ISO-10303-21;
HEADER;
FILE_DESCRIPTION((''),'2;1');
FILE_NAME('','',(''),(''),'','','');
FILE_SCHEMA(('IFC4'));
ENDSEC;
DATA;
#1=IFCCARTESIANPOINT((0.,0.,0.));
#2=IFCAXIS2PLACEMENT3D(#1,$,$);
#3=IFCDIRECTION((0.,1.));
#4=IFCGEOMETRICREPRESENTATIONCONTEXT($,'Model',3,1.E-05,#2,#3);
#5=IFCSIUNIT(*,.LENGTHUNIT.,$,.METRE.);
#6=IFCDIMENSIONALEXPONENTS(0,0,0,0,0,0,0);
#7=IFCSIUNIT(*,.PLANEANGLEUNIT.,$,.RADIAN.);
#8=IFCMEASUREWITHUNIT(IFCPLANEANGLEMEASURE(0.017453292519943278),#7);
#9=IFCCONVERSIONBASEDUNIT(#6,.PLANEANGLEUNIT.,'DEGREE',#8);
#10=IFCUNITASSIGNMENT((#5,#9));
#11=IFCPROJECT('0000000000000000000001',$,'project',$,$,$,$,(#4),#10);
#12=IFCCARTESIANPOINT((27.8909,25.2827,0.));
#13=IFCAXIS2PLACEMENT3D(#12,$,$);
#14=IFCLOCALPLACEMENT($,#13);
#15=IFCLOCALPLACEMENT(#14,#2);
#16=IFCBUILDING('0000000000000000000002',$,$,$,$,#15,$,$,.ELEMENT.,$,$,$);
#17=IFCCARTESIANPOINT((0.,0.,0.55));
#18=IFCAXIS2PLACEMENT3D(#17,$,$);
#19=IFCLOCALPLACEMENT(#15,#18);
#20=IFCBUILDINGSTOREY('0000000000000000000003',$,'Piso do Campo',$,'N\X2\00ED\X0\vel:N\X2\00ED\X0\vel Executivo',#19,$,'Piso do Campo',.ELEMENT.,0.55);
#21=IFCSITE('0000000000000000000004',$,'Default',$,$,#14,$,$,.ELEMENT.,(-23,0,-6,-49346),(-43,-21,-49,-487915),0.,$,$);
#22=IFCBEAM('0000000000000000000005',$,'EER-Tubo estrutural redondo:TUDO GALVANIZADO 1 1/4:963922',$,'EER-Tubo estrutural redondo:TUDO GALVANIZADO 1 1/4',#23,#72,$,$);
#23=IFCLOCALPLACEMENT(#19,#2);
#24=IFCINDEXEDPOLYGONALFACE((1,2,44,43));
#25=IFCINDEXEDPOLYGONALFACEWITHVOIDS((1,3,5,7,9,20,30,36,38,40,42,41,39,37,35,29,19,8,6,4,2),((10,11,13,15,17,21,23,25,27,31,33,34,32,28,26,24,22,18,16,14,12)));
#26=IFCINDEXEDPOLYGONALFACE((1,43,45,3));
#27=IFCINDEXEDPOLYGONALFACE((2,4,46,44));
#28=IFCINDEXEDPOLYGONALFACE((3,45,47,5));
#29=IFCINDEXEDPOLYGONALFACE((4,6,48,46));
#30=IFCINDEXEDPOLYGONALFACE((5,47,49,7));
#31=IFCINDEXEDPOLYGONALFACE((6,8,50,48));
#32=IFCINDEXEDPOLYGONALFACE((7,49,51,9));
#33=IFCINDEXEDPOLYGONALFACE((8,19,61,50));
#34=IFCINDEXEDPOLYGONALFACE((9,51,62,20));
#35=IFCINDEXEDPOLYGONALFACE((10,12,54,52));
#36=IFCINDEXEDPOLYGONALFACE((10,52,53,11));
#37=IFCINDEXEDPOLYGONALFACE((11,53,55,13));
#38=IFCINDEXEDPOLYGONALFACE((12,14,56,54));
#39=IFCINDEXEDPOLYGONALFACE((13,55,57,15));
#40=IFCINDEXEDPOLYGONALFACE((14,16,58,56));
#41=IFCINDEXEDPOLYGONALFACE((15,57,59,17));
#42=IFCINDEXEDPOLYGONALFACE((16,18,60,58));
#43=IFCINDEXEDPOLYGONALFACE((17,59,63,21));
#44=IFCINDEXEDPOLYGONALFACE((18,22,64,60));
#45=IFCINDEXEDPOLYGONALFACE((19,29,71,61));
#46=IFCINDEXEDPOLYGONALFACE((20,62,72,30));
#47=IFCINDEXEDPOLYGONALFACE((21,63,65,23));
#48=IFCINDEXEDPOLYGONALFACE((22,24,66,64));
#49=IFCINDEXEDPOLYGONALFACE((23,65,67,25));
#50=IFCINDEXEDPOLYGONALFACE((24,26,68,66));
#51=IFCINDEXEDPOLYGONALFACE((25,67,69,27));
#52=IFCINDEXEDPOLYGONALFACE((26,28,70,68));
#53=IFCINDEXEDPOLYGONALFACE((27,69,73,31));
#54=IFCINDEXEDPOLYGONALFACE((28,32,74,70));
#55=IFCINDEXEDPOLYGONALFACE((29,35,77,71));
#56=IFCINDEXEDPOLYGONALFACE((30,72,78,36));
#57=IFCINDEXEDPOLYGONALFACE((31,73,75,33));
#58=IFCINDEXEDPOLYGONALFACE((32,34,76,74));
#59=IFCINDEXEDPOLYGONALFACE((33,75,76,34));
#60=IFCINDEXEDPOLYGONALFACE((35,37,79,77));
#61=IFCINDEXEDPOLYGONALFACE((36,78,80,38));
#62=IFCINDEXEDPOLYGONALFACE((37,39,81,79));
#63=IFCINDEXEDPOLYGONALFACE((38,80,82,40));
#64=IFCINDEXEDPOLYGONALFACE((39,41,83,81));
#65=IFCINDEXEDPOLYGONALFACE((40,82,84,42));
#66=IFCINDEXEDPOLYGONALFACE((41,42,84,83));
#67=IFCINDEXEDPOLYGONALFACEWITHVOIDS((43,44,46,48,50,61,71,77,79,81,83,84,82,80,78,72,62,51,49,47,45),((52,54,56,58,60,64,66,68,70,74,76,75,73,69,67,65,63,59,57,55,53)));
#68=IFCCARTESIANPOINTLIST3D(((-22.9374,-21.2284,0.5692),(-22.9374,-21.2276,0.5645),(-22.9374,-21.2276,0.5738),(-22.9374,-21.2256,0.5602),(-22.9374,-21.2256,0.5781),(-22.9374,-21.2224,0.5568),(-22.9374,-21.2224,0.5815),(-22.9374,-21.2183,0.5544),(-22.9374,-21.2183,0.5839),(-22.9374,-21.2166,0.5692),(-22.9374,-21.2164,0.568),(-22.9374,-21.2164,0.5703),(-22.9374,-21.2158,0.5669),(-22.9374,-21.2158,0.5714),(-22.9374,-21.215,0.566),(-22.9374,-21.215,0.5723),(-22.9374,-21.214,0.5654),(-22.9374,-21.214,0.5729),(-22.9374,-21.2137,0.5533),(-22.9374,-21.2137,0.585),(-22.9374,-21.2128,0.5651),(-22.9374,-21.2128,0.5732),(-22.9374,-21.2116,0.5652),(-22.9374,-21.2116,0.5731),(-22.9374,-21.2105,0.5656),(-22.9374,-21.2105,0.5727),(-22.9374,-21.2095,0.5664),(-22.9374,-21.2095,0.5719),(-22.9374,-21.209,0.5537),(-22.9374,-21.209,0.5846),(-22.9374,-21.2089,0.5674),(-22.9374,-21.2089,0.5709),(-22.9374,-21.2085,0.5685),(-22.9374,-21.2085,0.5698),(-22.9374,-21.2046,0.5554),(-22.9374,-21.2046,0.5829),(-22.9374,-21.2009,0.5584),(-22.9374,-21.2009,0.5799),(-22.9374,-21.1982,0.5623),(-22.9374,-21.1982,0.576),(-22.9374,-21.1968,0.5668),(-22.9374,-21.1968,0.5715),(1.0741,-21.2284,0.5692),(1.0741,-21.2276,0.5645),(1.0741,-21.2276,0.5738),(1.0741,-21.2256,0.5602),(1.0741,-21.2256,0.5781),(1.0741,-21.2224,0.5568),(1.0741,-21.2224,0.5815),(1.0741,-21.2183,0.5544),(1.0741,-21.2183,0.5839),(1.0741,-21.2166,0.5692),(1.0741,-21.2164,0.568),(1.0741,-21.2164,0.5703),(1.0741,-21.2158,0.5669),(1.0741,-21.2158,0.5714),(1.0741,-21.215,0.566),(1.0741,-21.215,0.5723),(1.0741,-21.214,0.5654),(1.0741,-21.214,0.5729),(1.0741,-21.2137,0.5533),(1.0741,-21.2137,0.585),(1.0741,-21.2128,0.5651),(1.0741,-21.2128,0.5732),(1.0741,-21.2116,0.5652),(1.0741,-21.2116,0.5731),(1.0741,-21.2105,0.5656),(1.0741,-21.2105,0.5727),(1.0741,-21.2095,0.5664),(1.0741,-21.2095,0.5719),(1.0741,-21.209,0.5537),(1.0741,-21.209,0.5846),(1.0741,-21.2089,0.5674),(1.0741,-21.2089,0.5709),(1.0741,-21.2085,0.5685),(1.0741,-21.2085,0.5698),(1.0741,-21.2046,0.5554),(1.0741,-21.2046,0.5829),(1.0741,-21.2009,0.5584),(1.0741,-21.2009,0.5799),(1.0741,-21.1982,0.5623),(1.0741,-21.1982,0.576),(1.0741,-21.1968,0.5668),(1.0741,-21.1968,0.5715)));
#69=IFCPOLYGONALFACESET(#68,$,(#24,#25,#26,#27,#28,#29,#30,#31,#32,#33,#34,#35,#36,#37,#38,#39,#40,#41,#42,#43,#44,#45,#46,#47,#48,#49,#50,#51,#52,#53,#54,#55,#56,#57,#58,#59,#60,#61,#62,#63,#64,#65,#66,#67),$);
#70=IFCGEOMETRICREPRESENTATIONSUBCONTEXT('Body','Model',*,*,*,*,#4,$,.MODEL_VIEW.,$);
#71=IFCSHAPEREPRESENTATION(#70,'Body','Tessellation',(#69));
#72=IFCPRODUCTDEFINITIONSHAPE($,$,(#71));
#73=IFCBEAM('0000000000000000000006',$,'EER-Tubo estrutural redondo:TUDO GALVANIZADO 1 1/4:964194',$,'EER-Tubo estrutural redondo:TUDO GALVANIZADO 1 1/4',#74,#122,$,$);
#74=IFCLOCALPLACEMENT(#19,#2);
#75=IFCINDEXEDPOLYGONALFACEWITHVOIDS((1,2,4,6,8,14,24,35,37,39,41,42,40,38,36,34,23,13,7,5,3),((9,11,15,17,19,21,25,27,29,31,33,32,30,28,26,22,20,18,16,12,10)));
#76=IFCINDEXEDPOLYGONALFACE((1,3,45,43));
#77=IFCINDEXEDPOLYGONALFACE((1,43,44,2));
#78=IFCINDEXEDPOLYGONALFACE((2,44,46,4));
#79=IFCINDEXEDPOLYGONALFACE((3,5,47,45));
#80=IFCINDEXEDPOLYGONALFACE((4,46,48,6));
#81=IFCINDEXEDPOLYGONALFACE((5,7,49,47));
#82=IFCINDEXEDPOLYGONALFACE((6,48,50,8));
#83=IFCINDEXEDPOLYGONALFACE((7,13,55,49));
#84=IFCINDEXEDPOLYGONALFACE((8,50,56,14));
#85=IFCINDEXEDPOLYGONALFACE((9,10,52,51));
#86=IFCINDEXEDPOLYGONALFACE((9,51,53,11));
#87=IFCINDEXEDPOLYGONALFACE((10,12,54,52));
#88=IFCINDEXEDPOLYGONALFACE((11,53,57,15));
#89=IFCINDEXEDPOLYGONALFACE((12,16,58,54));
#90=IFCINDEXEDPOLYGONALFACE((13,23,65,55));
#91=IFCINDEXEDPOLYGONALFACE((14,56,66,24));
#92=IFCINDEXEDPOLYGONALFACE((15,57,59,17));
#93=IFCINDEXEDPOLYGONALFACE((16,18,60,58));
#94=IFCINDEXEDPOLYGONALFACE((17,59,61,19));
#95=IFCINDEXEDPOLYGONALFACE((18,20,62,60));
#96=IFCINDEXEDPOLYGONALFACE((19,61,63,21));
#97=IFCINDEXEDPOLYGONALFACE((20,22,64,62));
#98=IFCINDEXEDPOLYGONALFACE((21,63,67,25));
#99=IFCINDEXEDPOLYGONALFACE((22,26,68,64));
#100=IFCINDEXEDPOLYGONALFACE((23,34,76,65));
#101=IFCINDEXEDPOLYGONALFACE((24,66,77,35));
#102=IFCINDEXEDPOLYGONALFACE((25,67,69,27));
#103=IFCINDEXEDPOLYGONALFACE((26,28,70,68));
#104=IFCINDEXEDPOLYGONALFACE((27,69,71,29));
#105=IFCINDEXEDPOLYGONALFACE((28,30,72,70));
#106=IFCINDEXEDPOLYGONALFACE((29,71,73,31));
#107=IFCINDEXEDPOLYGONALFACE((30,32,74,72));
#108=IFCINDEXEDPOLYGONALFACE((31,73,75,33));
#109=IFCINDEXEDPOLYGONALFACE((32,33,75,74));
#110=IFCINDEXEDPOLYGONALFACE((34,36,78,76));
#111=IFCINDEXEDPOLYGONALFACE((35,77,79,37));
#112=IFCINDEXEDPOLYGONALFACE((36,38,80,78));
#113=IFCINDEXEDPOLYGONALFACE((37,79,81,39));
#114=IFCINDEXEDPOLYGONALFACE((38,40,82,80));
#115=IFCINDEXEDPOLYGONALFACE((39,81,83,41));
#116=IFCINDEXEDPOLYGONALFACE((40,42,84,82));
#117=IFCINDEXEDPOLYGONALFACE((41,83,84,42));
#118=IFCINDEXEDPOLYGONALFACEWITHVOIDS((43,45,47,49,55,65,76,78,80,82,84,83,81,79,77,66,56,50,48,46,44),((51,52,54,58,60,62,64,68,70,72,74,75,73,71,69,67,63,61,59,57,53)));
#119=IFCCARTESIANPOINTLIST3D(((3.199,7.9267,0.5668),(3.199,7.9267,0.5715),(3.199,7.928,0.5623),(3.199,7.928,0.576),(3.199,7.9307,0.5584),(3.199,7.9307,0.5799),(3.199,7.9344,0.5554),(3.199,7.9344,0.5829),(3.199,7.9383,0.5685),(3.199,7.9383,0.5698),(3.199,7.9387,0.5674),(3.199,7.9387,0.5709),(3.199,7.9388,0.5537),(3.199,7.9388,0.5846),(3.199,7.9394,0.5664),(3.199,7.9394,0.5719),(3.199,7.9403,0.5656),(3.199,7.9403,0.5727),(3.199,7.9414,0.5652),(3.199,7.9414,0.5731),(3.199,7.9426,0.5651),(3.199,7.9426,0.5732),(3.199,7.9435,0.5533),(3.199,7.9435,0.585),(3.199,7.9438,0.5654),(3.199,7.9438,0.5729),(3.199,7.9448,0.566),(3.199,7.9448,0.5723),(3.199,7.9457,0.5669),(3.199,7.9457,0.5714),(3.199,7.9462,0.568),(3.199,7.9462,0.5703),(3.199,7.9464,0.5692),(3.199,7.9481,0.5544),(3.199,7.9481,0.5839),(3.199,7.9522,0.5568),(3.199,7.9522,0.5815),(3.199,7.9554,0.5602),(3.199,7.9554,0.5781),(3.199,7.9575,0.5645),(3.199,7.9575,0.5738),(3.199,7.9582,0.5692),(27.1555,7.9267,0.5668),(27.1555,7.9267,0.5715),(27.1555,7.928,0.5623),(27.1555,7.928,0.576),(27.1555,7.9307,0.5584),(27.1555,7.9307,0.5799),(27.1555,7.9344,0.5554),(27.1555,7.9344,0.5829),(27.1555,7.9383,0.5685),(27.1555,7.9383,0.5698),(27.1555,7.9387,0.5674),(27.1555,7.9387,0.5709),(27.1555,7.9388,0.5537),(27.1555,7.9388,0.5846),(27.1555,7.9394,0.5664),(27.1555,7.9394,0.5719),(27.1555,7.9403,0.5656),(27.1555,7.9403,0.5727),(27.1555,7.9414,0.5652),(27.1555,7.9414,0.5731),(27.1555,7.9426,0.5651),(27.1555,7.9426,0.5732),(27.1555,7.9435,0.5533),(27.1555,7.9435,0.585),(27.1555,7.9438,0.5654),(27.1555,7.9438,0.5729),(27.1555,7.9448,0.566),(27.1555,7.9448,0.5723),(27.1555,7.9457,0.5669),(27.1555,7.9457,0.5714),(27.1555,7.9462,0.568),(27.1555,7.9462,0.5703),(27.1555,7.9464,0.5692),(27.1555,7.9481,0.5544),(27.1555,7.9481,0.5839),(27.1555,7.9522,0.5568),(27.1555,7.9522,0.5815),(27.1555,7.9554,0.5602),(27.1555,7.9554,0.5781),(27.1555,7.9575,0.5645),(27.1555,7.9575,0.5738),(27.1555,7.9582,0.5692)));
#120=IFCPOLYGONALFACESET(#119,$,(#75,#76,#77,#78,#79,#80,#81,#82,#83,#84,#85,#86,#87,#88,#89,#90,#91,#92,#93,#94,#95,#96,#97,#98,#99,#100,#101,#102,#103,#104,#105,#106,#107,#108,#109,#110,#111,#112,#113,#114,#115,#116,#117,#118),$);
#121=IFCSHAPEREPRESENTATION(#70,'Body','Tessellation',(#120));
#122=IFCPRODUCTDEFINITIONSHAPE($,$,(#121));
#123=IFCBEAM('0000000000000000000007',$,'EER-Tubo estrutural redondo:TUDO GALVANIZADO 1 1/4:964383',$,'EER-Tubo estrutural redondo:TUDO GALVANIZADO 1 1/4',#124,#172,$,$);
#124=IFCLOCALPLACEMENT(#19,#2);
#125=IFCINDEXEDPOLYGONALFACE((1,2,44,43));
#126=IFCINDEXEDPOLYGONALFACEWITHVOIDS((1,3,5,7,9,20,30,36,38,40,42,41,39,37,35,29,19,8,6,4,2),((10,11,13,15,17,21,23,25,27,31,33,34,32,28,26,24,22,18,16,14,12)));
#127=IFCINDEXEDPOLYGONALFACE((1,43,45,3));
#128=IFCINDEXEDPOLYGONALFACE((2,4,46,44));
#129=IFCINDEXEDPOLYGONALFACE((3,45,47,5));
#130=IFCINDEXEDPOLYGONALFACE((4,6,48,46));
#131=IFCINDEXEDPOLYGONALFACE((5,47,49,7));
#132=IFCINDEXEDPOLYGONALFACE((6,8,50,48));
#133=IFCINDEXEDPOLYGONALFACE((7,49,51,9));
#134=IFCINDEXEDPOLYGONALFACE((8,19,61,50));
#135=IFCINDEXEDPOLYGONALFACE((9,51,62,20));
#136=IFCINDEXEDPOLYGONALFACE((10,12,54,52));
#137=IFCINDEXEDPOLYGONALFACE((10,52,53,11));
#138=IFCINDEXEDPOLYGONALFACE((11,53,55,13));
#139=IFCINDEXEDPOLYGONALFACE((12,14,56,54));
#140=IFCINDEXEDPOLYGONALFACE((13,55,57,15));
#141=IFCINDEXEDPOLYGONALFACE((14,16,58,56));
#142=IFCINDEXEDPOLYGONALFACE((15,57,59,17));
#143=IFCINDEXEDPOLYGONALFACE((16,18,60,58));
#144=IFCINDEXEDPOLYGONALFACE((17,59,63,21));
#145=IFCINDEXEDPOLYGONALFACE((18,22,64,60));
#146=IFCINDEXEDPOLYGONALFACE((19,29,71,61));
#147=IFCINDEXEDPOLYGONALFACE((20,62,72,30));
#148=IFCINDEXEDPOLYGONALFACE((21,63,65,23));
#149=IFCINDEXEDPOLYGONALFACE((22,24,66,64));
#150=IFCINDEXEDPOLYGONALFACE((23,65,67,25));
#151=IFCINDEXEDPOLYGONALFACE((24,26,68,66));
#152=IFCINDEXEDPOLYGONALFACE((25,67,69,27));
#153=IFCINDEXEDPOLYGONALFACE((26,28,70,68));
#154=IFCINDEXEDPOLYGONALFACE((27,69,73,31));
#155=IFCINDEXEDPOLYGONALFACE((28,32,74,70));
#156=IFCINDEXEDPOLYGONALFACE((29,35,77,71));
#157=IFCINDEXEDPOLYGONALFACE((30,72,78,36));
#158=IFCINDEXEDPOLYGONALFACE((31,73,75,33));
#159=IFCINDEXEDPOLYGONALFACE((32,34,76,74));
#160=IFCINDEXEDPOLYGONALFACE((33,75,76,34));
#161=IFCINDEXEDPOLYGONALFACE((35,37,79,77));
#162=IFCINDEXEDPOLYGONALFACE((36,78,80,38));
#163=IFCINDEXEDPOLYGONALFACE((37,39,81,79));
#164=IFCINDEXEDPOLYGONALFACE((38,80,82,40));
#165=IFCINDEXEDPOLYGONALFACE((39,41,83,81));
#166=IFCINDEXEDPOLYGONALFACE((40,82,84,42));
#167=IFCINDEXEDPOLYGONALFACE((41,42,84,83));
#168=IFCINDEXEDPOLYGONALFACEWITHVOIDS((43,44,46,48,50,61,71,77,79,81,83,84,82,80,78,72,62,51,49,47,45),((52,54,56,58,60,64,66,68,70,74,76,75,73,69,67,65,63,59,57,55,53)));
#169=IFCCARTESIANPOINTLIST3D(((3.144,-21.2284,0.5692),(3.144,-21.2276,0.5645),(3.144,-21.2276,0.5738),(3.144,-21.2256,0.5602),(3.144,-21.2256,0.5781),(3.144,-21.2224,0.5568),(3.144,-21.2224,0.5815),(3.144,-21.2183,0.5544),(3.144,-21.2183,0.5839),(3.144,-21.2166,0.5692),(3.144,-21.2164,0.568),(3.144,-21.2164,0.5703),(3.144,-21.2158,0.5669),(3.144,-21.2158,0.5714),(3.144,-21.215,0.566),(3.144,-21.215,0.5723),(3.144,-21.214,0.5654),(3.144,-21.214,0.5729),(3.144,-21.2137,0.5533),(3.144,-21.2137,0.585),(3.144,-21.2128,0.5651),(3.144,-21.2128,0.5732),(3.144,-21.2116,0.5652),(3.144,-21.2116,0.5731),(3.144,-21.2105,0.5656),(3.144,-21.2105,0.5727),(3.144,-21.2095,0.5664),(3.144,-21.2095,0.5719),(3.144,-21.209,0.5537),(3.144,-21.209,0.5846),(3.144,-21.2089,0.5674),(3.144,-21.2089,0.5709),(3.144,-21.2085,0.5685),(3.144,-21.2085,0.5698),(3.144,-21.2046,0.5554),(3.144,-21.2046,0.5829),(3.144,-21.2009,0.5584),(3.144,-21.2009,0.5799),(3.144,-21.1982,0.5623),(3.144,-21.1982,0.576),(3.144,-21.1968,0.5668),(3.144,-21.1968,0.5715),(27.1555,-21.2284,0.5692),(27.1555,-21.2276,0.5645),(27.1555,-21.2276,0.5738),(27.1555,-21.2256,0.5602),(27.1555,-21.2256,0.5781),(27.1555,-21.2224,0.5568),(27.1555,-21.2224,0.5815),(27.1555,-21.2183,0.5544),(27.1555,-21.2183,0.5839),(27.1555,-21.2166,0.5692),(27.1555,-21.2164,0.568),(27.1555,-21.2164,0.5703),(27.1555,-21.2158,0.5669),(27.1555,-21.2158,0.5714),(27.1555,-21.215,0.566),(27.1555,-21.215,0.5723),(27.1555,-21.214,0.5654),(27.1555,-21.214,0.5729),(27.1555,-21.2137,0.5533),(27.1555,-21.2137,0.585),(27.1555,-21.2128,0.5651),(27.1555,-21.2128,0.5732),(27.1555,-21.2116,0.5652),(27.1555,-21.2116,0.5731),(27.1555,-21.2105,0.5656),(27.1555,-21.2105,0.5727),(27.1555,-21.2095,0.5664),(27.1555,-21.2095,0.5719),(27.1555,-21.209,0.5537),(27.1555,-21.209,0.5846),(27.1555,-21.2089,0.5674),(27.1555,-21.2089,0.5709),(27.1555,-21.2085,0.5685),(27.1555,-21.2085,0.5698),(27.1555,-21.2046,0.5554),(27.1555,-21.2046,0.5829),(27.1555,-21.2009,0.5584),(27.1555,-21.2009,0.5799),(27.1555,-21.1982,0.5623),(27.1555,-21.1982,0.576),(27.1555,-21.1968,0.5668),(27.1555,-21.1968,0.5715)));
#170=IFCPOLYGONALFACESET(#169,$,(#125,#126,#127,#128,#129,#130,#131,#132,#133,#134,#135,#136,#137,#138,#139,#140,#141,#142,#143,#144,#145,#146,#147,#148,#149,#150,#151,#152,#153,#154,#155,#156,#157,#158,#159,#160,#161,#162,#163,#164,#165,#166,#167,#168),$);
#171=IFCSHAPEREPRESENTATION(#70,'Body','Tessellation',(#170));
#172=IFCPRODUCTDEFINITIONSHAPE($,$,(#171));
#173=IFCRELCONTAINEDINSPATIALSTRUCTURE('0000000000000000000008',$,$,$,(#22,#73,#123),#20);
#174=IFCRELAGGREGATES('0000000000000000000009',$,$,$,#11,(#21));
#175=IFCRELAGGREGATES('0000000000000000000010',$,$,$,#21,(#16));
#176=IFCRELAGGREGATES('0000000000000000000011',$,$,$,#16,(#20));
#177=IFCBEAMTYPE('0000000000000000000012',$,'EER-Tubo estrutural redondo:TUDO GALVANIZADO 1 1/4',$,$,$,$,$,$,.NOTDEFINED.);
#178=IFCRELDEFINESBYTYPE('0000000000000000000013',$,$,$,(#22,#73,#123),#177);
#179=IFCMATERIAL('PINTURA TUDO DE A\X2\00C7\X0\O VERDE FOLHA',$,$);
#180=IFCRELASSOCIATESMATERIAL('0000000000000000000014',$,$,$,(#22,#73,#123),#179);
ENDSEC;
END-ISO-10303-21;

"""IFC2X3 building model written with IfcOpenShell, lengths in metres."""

from ifc_helpers import new_model, entity, si_unit, converted_unit, direction, frame, origin, origin_2d_with_axis, place, context, subcontext, project, spatial, hollow_circle, extrude, material, type_object, element, save


model = new_model("IFC2X3")

# Units and contexts
model_context = context("Model", 3, precision=1e-05, world=origin(), true_north=direction((0.0, 1.0)))
body_context = subcontext(model_context, "Body", "Model", "MODEL_VIEW")
ifc_project = project(units=[si_unit("LENGTHUNIT", "METRE"), converted_unit("PLANEANGLEUNIT", "DEGREE", entity("IfcPlaneAngleMeasure", 0.017453292519943278), si_unit("PLANEANGLEUNIT", "RADIAN"), dimensions=[0, 0, 0, 0, 0, 0, 0])], contexts=[model_context])

# Site, building, storey
site_placement = place(None, frame((27.8909, 25.2827, 0.0)))
site = spatial("IfcSite", under=ifc_project, at=site_placement, Name="Default", CompositionType="ELEMENT", RefLatitude=(-23, 0, -6, -49346), RefLongitude=(-43, -21, -49, -487915), RefElevation=0.0)
building_placement = place(site_placement, origin())
building = spatial("IfcBuilding", under=site, at=building_placement, CompositionType="ELEMENT")
storey_placement = place(building_placement, frame((0.0, 0.0, 0.55)))
storey = spatial("IfcBuildingStorey", under=building, at=storey_placement, Name="Piso do Campo", ObjectType="Nível:Nível Executivo", LongName="Piso do Campo", CompositionType="ELEMENT", Elevation=0.55)

# Beams
ifc_material = material(Name="PINTURA TUDO DE AÇO VERDE FOLHA")
beam_type = type_object("IfcBeamType", Name="EER-Tubo estrutural redondo:TUDO GALVANIZADO 1 1/4", PredefinedType="NOTDEFINED")
beam_1_placement = place(storey_placement, frame((-22.9659, -21.2125, 0.585)))
element("IfcBeam", 1, at=beam_1_placement, inside=storey, type_object=beam_type, material=ifc_material, Name="EER-Tubo estrutural redondo:TUDO GALVANIZADO 1 1/4:963922", ObjectType="EER-Tubo estrutural redondo:TUDO GALVANIZADO 1 1/4", context=body_context, shape_type="SweptSolid", body=[
    extrude(hollow_circle(Radius=0.0159, WallThickness=0.0118, at=origin_2d_with_axis()), frame((0.0286, 0.0, -0.0159), z_axis=(1.0, 0.0, 0.0), x_axis=(0.0, -1.0, 0.0)), (0.0, 0.0, 1.0), 24.0115),
])
beam_2_placement = place(storey_placement, frame((2.2041, 7.9423, 0.585)))
element("IfcBeam", 2, at=beam_2_placement, inside=storey, type_object=beam_type, material=ifc_material, Name="EER-Tubo estrutural redondo:TUDO GALVANIZADO 1 1/4:964194", ObjectType="EER-Tubo estrutural redondo:TUDO GALVANIZADO 1 1/4", context=body_context, shape_type="SweptSolid", body=[
    extrude(hollow_circle(Radius=0.0159, WallThickness=0.0118, at=origin_2d_with_axis()), frame((0.995, 0.0, -0.0159), z_axis=(1.0, 0.0, 0.0), x_axis=(0.0, 1.0, 0.0)), (0.0, 0.0, 1.0), 23.9565),
])
beam_3_placement = place(storey_placement, frame((2.0541, -21.2125, 0.585)))
element("IfcBeam", 3, at=beam_3_placement, inside=storey, type_object=beam_type, material=ifc_material, Name="EER-Tubo estrutural redondo:TUDO GALVANIZADO 1 1/4:964383", ObjectType="EER-Tubo estrutural redondo:TUDO GALVANIZADO 1 1/4", context=body_context, shape_type="SweptSolid", body=[
    extrude(hollow_circle(Radius=0.0159, WallThickness=0.0118, at=origin_2d_with_axis()), frame((1.09, 0.0, -0.0159), z_axis=(1.0, 0.0, 0.0), x_axis=(0.0, -1.0, 0.0)), (0.0, 0.0, 1.0), 24.0115),
])

save(model, "model.ifc")
